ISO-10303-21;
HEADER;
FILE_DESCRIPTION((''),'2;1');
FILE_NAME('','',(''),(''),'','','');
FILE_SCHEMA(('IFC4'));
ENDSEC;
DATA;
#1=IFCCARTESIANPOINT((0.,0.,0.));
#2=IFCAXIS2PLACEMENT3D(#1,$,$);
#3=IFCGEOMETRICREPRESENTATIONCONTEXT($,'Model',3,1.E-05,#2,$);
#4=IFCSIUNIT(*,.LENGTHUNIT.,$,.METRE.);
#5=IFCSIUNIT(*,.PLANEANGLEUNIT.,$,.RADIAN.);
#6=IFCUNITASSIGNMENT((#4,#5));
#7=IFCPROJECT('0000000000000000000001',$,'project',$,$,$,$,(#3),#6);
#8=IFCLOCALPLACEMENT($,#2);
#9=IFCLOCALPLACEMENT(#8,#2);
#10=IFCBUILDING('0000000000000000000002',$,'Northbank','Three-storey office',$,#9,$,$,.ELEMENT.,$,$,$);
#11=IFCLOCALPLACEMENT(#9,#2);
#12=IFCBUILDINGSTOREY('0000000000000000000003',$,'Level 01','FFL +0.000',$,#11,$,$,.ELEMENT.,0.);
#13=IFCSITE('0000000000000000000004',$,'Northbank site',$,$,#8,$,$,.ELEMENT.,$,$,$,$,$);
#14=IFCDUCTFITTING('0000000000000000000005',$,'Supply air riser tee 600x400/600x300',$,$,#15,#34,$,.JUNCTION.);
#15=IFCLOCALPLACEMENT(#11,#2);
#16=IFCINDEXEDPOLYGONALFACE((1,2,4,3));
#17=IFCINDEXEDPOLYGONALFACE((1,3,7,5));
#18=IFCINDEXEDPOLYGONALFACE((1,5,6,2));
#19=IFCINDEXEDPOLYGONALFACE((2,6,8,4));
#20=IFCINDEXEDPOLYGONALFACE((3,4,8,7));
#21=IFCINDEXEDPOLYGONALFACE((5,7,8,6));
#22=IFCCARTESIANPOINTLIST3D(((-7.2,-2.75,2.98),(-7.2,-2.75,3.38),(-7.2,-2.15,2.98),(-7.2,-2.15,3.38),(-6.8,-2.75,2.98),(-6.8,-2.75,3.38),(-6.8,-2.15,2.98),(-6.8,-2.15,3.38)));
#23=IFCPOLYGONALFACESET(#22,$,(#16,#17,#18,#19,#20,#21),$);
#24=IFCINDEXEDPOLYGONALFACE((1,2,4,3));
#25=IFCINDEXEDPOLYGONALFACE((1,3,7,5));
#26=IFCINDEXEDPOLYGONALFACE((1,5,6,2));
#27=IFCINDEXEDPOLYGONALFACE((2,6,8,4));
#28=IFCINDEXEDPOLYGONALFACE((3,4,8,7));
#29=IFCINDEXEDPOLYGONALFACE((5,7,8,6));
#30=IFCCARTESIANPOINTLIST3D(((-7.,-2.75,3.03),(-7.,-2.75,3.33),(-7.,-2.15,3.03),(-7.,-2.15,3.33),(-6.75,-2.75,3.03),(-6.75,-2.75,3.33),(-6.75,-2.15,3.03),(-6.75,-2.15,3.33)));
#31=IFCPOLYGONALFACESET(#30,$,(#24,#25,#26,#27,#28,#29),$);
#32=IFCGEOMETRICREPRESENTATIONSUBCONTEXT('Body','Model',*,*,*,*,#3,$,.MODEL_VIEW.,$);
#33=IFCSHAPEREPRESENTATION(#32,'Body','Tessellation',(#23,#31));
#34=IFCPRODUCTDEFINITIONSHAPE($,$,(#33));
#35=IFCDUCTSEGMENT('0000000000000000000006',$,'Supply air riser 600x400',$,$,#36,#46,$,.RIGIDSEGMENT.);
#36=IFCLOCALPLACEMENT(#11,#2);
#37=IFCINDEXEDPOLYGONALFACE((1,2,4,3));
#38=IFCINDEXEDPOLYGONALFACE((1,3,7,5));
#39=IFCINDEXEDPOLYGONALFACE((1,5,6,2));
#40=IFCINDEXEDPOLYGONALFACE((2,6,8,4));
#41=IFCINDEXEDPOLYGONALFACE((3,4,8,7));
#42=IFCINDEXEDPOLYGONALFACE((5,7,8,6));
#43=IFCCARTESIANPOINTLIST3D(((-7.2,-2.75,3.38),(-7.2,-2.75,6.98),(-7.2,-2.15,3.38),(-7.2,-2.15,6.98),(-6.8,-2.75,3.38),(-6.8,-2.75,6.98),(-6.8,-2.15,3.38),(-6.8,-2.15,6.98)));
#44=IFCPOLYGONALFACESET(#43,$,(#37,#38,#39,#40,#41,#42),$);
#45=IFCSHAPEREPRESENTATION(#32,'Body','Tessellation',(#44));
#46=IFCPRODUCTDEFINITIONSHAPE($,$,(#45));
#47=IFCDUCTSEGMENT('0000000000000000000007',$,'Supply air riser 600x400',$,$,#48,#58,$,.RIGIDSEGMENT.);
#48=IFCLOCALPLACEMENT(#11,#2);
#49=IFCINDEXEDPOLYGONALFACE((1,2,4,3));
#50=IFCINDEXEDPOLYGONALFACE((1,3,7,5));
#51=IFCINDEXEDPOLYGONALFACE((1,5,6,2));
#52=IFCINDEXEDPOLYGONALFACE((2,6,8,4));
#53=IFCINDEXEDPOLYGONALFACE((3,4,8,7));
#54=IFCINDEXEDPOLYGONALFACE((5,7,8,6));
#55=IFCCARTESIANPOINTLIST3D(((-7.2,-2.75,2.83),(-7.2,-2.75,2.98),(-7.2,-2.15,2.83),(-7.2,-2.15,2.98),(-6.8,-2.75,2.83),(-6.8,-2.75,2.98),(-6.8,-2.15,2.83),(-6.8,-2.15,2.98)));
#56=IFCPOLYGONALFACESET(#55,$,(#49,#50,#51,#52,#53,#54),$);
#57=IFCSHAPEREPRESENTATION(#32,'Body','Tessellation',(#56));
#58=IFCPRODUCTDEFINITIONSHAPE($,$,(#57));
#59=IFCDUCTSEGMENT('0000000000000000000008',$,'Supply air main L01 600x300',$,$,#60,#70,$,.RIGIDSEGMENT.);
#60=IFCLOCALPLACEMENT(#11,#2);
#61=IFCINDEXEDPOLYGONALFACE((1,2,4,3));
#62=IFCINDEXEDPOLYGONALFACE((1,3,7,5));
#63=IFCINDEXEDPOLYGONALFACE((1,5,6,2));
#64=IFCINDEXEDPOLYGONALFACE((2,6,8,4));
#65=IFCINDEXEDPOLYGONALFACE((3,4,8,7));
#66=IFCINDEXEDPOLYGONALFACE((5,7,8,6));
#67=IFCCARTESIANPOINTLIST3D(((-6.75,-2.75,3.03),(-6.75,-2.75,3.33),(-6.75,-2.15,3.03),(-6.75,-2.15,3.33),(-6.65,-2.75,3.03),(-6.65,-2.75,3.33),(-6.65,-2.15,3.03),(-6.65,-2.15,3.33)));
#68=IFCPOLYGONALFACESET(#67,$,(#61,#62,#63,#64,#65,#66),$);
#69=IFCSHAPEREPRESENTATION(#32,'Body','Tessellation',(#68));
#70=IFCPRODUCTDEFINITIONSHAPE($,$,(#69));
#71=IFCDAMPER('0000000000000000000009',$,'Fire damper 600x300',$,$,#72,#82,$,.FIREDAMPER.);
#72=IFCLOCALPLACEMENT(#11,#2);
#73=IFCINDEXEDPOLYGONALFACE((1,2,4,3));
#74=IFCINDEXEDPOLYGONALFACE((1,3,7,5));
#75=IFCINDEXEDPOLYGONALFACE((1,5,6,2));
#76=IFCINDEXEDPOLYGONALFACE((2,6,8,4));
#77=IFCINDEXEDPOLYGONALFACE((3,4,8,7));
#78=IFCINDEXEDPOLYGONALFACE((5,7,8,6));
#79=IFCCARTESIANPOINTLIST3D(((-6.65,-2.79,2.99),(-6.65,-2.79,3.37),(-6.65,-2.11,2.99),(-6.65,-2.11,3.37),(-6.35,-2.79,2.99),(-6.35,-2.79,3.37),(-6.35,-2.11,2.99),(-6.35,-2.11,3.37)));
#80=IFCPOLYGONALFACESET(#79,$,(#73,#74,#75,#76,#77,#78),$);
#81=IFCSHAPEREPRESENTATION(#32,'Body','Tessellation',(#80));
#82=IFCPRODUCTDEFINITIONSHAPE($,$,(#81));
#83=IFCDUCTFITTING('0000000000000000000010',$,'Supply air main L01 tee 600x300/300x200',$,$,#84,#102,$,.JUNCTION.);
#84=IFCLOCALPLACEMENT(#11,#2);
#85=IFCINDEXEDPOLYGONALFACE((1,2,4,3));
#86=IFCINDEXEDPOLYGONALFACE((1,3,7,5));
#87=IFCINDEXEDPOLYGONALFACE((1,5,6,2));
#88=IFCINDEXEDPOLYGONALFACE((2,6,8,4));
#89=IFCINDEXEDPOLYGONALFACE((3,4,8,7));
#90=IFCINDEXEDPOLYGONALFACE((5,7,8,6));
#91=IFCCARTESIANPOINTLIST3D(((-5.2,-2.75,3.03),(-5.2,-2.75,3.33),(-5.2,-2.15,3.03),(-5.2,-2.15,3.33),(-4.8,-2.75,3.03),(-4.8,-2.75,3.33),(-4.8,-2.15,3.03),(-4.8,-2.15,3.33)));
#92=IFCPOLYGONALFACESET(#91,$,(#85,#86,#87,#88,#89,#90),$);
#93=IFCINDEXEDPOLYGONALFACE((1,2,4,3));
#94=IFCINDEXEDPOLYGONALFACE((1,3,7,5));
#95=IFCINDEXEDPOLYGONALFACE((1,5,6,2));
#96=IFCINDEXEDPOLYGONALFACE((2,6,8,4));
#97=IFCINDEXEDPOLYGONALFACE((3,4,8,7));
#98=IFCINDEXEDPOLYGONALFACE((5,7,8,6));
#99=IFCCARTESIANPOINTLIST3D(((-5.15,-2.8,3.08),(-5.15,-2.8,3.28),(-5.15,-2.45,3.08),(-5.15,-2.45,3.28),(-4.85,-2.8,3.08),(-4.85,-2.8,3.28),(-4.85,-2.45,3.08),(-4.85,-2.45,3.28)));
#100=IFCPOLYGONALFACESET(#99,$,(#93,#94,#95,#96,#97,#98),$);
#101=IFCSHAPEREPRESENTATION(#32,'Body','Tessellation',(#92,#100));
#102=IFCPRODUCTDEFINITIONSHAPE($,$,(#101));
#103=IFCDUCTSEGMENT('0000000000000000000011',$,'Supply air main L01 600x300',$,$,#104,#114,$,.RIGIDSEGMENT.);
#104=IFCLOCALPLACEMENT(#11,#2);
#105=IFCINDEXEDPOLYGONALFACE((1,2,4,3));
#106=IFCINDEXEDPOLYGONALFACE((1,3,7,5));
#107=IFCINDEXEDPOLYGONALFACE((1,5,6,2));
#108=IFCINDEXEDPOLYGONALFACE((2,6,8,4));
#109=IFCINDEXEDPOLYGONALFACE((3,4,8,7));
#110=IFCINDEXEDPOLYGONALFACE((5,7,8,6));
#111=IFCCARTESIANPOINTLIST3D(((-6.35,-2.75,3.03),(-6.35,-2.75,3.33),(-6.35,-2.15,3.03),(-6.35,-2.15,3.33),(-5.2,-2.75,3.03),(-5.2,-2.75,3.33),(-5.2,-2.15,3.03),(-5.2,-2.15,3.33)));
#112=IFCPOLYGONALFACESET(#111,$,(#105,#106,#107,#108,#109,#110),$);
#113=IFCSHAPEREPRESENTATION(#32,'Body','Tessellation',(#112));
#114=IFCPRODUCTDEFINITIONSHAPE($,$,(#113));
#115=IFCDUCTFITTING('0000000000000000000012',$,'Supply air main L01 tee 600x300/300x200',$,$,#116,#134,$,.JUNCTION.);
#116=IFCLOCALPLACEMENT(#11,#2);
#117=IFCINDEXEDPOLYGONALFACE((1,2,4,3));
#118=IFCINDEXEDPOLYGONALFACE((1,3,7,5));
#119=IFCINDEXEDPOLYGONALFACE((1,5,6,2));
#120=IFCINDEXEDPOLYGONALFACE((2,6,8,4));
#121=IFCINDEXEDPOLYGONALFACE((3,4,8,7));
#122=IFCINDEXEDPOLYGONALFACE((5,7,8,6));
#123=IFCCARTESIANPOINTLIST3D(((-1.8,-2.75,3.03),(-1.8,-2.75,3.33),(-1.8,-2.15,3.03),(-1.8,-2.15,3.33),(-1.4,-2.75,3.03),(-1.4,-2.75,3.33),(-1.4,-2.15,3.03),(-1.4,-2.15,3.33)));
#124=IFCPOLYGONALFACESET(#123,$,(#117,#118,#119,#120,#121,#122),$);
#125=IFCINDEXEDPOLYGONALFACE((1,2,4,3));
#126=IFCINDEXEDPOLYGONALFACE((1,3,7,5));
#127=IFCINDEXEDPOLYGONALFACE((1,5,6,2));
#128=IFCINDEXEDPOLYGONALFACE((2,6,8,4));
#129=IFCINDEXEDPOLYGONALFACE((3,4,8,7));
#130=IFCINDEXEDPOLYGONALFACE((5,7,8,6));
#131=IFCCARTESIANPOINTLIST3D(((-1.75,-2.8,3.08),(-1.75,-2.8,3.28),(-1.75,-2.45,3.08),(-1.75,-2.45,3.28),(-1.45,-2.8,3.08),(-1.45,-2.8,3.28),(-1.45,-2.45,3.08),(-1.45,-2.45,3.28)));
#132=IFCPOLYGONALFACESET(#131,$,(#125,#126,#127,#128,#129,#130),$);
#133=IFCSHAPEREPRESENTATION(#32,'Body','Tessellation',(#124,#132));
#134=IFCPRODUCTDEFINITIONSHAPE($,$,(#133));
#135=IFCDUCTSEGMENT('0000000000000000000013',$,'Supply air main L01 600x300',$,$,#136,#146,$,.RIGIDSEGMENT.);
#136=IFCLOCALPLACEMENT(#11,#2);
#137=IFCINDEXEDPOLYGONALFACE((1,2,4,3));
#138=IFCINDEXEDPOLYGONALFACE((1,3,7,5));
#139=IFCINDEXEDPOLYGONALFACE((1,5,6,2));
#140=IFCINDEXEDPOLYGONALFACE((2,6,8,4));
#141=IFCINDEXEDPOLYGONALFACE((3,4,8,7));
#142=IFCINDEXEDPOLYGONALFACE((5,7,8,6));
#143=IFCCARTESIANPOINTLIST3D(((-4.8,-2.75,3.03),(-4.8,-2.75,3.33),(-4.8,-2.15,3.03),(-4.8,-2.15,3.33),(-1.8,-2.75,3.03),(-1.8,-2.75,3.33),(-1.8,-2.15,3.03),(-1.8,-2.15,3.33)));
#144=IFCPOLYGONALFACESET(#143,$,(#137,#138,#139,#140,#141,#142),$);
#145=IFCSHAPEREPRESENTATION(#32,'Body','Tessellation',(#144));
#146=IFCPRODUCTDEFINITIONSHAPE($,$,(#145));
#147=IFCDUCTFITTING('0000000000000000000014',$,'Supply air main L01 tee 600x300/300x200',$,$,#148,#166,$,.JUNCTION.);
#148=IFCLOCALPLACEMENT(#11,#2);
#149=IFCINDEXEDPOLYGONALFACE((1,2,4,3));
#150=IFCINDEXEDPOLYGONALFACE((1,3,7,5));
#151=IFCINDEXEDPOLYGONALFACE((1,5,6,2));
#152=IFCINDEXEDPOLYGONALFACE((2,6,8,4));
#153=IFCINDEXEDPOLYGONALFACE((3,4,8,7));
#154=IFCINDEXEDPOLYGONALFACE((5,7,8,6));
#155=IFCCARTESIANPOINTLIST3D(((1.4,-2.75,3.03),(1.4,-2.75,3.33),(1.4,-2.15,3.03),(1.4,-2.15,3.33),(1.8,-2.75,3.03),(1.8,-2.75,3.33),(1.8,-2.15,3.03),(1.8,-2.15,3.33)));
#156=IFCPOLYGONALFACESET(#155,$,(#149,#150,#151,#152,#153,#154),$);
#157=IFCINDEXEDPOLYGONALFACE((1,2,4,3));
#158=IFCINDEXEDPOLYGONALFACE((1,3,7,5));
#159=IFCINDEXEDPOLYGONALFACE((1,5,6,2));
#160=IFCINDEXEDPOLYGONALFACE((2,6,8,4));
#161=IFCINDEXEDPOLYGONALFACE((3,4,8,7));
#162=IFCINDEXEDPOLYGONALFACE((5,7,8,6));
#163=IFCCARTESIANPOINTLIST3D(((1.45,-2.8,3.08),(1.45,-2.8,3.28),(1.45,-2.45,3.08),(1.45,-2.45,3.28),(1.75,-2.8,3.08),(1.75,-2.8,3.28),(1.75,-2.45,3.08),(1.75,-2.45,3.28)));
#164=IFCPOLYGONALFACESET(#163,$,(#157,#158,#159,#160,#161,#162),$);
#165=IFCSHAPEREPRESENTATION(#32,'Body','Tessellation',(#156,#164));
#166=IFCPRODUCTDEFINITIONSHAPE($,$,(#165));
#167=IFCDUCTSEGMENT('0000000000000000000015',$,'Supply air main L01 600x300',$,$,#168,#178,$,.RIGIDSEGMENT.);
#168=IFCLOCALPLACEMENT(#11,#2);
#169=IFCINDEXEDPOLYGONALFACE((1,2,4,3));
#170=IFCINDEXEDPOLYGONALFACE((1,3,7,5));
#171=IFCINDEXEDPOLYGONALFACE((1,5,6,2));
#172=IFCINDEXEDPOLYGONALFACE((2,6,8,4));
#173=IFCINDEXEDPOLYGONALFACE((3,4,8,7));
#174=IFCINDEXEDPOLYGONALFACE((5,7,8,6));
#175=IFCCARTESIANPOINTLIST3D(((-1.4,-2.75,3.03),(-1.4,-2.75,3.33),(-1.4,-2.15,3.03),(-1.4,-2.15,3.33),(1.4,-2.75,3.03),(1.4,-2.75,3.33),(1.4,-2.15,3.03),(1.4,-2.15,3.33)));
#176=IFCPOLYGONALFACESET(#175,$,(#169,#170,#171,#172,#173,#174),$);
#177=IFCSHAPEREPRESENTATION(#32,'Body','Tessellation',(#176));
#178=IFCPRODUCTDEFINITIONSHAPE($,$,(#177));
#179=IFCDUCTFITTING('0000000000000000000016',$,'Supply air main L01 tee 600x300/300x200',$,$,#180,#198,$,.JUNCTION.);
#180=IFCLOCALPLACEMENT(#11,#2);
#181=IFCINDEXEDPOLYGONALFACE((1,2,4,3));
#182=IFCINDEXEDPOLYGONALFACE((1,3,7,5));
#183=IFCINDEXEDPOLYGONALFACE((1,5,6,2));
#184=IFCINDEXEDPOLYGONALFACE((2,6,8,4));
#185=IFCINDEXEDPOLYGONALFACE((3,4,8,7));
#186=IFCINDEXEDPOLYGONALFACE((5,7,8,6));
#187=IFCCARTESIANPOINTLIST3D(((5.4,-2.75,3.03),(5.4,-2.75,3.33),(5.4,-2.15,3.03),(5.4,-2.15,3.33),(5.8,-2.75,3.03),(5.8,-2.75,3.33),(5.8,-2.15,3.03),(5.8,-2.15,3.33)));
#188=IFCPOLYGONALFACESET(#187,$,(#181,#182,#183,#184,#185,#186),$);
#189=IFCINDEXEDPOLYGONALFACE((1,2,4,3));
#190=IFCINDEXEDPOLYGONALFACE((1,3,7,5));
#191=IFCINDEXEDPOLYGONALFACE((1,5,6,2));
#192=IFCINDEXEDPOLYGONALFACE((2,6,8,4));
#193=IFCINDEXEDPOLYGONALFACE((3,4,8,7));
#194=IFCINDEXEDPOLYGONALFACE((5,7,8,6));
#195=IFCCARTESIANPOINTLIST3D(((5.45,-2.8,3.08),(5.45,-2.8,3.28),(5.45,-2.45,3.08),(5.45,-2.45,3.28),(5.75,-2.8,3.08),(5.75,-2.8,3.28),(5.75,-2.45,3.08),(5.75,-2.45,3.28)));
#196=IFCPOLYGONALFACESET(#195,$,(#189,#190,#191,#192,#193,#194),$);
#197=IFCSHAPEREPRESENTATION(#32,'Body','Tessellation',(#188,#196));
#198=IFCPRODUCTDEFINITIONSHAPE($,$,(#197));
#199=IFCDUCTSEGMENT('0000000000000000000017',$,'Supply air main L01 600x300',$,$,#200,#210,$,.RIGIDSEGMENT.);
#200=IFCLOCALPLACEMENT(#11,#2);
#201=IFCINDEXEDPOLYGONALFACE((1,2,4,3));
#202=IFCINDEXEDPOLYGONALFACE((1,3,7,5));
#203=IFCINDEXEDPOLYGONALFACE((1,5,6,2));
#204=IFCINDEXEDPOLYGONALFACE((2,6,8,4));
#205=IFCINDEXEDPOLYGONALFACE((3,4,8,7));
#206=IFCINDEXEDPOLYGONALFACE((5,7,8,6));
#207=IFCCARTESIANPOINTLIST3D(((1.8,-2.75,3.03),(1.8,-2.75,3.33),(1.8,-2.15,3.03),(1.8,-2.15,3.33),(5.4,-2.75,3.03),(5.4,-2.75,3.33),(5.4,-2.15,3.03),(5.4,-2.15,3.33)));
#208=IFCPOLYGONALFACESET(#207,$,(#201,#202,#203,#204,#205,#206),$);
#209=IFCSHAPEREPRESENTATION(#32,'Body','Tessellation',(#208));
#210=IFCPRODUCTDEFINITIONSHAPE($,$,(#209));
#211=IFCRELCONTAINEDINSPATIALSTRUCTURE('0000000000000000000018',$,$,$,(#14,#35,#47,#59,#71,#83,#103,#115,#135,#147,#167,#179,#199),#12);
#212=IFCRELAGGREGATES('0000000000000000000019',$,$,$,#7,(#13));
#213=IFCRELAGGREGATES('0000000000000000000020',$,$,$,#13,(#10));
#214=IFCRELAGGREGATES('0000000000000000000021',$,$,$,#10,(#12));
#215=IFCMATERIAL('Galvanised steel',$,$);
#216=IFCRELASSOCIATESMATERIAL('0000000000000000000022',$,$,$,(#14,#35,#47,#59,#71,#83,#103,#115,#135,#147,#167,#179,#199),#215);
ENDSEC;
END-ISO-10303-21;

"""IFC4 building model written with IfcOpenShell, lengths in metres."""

from ifc_helpers import new_model, si_unit, frame, origin, place, context, subcontext, project, spatial, rectangle, extrude, material, element, save


model = new_model("IFC4")

# Units and contexts
model_context = context("Model", 3, precision=1e-05, world=origin())
body_context = subcontext(model_context, "Body", "Model", "MODEL_VIEW")
ifc_project = project(units=[si_unit("LENGTHUNIT", "METRE"), si_unit("PLANEANGLEUNIT", "RADIAN")], contexts=[model_context])

# Site, building, storey
site_placement = place(None, origin())
site = spatial("IfcSite", under=ifc_project, at=site_placement, Name="Northbank site", CompositionType="ELEMENT")
building_placement = place(site_placement, origin())
building = spatial("IfcBuilding", under=site, at=building_placement, Name="Northbank", Description="Three-storey office", CompositionType="ELEMENT")
storey_placement = place(building_placement, origin())
storey = spatial("IfcBuildingStorey", under=building, at=storey_placement, Name="Level 01", Description="FFL +0.000", CompositionType="ELEMENT", Elevation=0.0)

# Duct fitting
ifc_material_1 = material(Name="Galvanised steel")
duct_fitting_1_placement = place(storey_placement, origin())
element("IfcDuctFitting", 1, at=duct_fitting_1_placement, inside=storey, material=ifc_material_1, Name="Supply air riser tee 600x400/600x300", PredefinedType="JUNCTION", context=body_context, shape_type="SweptSolid", body=[
    extrude(rectangle(XDim=0.6, YDim=0.4), frame((-7.0, -2.45, 3.38), z_axis=(0.0, 0.0, -1.0), x_axis=(0.0, -1.0, 0.0)), (0.0, 0.0, 1.0), 0.4),
    extrude(rectangle(XDim=0.6, YDim=0.3), frame((-7.0, -2.45, 3.18), z_axis=(1.0, 0.0, 0.0), x_axis=(0.0, 1.0, 0.0)), (0.0, 0.0, 1.0), 0.25),
])

# Duct segments
duct_segment_1_placement = place(storey_placement, origin())
element("IfcDuctSegment", 2, at=duct_segment_1_placement, inside=storey, material=ifc_material_1, Name="Supply air riser 600x400", PredefinedType="RIGIDSEGMENT", context=body_context, shape_type="SweptSolid", body=[
    extrude(rectangle(XDim=0.6, YDim=0.4), frame((-7.0, -2.45, 6.98), z_axis=(0.0, 0.0, -1.0), x_axis=(0.0, -1.0, 0.0)), (0.0, 0.0, 1.0), 3.6),
])
duct_segment_2_placement = place(storey_placement, origin())
element("IfcDuctSegment", 3, at=duct_segment_2_placement, inside=storey, material=ifc_material_1, Name="Supply air riser 600x400", PredefinedType="RIGIDSEGMENT", context=body_context, shape_type="SweptSolid", body=[
    extrude(rectangle(XDim=0.6, YDim=0.4), frame((-7.0, -2.45, 2.98), z_axis=(0.0, 0.0, -1.0), x_axis=(0.0, -1.0, 0.0)), (0.0, 0.0, 1.0), 0.15),
])
duct_segment_3_placement = place(storey_placement, origin())
element("IfcDuctSegment", 4, at=duct_segment_3_placement, inside=storey, material=ifc_material_1, Name="Supply air main L01 600x300", PredefinedType="RIGIDSEGMENT", context=body_context, shape_type="SweptSolid", body=[
    extrude(rectangle(XDim=0.6, YDim=0.3), frame((-6.75, -2.45, 3.18), z_axis=(1.0, 0.0, 0.0), x_axis=(0.0, 1.0, 0.0)), (0.0, 0.0, 1.0), 0.1),
])

# Damper
damper_1_placement = place(storey_placement, origin())
element("IfcDamper", 5, at=damper_1_placement, inside=storey, material=ifc_material_1, Name="Fire damper 600x300", PredefinedType="FIREDAMPER", context=body_context, shape_type="SweptSolid", body=[
    extrude(rectangle(XDim=0.68, YDim=0.38), frame((-6.65, -2.45, 3.18), z_axis=(1.0, 0.0, 0.0), x_axis=(0.0, 1.0, 0.0)), (0.0, 0.0, 1.0), 0.3),
])

# Duct fitting
duct_fitting_2_placement = place(storey_placement, origin())
element("IfcDuctFitting", 6, at=duct_fitting_2_placement, inside=storey, material=ifc_material_1, Name="Supply air main L01 tee 600x300/300x200", PredefinedType="JUNCTION", context=body_context, shape_type="SweptSolid", body=[
    extrude(rectangle(XDim=0.6, YDim=0.3), frame((-5.2, -2.45, 3.18), z_axis=(1.0, 0.0, 0.0), x_axis=(0.0, 1.0, 0.0)), (0.0, 0.0, 1.0), 0.4),
    extrude(rectangle(XDim=0.3, YDim=0.2), frame((-5.0, -2.45, 3.18), z_axis=(0.0, -1.0, 0.0), x_axis=(1.0, 0.0, 0.0)), (0.0, 0.0, 1.0), 0.35),
])

# Duct segment
duct_segment_4_placement = place(storey_placement, origin())
element("IfcDuctSegment", 7, at=duct_segment_4_placement, inside=storey, material=ifc_material_1, Name="Supply air main L01 600x300", PredefinedType="RIGIDSEGMENT", context=body_context, shape_type="SweptSolid", body=[
    extrude(rectangle(XDim=0.6, YDim=0.3), frame((-6.35, -2.45, 3.18), z_axis=(1.0, 0.0, 0.0), x_axis=(0.0, 1.0, 0.0)), (0.0, 0.0, 1.0), 1.15),
])

# Duct fitting
duct_fitting_3_placement = place(storey_placement, origin())
element("IfcDuctFitting", 8, at=duct_fitting_3_placement, inside=storey, material=ifc_material_1, Name="Supply air main L01 tee 600x300/300x200", PredefinedType="JUNCTION", context=body_context, shape_type="SweptSolid", body=[
    extrude(rectangle(XDim=0.6, YDim=0.3), frame((-1.8, -2.45, 3.18), z_axis=(1.0, 0.0, 0.0), x_axis=(0.0, 1.0, 0.0)), (0.0, 0.0, 1.0), 0.4),
    extrude(rectangle(XDim=0.3, YDim=0.2), frame((-1.6, -2.45, 3.18), z_axis=(0.0, -1.0, 0.0), x_axis=(1.0, 0.0, 0.0)), (0.0, 0.0, 1.0), 0.35),
])

# Duct segment
duct_segment_5_placement = place(storey_placement, origin())
element("IfcDuctSegment", 9, at=duct_segment_5_placement, inside=storey, material=ifc_material_1, Name="Supply air main L01 600x300", PredefinedType="RIGIDSEGMENT", context=body_context, shape_type="SweptSolid", body=[
    extrude(rectangle(XDim=0.6, YDim=0.3), frame((-4.8, -2.45, 3.18), z_axis=(1.0, 0.0, 0.0), x_axis=(0.0, 1.0, 0.0)), (0.0, 0.0, 1.0), 3.0),
])

# Duct fitting
duct_fitting_4_placement = place(storey_placement, origin())
element("IfcDuctFitting", 10, at=duct_fitting_4_placement, inside=storey, material=ifc_material_1, Name="Supply air main L01 tee 600x300/300x200", PredefinedType="JUNCTION", context=body_context, shape_type="SweptSolid", body=[
    extrude(rectangle(XDim=0.6, YDim=0.3), frame((1.4, -2.45, 3.18), z_axis=(1.0, 0.0, 0.0), x_axis=(0.0, 1.0, 0.0)), (0.0, 0.0, 1.0), 0.4),
    extrude(rectangle(XDim=0.3, YDim=0.2), frame((1.6, -2.45, 3.18), z_axis=(0.0, -1.0, 0.0), x_axis=(1.0, 0.0, 0.0)), (0.0, 0.0, 1.0), 0.35),
])

# Duct segment
duct_segment_6_placement = place(storey_placement, origin())
element("IfcDuctSegment", 11, at=duct_segment_6_placement, inside=storey, material=ifc_material_1, Name="Supply air main L01 600x300", PredefinedType="RIGIDSEGMENT", context=body_context, shape_type="SweptSolid", body=[
    extrude(rectangle(XDim=0.6, YDim=0.3), frame((-1.4, -2.45, 3.18), z_axis=(1.0, 0.0, 0.0), x_axis=(0.0, 1.0, 0.0)), (0.0, 0.0, 1.0), 2.8),
])

# Duct fitting
duct_fitting_5_placement = place(storey_placement, origin())
element("IfcDuctFitting", 12, at=duct_fitting_5_placement, inside=storey, material=ifc_material_1, Name="Supply air main L01 tee 600x300/300x200", PredefinedType="JUNCTION", context=body_context, shape_type="SweptSolid", body=[
    extrude(rectangle(XDim=0.6, YDim=0.3), frame((5.4, -2.45, 3.18), z_axis=(1.0, 0.0, 0.0), x_axis=(0.0, 1.0, 0.0)), (0.0, 0.0, 1.0), 0.4),
    extrude(rectangle(XDim=0.3, YDim=0.2), frame((5.6, -2.45, 3.18), z_axis=(0.0, -1.0, 0.0), x_axis=(1.0, 0.0, 0.0)), (0.0, 0.0, 1.0), 0.35),
])

# Duct segment
duct_segment_7_placement = place(storey_placement, origin())
element("IfcDuctSegment", 13, at=duct_segment_7_placement, inside=storey, material=ifc_material_1, Name="Supply air main L01 600x300", PredefinedType="RIGIDSEGMENT", context=body_context, shape_type="SweptSolid", body=[
    extrude(rectangle(XDim=0.6, YDim=0.3), frame((1.8, -2.45, 3.18), z_axis=(1.0, 0.0, 0.0), x_axis=(0.0, 1.0, 0.0)), (0.0, 0.0, 1.0), 3.6),
])

save(model, "model.ifc")
